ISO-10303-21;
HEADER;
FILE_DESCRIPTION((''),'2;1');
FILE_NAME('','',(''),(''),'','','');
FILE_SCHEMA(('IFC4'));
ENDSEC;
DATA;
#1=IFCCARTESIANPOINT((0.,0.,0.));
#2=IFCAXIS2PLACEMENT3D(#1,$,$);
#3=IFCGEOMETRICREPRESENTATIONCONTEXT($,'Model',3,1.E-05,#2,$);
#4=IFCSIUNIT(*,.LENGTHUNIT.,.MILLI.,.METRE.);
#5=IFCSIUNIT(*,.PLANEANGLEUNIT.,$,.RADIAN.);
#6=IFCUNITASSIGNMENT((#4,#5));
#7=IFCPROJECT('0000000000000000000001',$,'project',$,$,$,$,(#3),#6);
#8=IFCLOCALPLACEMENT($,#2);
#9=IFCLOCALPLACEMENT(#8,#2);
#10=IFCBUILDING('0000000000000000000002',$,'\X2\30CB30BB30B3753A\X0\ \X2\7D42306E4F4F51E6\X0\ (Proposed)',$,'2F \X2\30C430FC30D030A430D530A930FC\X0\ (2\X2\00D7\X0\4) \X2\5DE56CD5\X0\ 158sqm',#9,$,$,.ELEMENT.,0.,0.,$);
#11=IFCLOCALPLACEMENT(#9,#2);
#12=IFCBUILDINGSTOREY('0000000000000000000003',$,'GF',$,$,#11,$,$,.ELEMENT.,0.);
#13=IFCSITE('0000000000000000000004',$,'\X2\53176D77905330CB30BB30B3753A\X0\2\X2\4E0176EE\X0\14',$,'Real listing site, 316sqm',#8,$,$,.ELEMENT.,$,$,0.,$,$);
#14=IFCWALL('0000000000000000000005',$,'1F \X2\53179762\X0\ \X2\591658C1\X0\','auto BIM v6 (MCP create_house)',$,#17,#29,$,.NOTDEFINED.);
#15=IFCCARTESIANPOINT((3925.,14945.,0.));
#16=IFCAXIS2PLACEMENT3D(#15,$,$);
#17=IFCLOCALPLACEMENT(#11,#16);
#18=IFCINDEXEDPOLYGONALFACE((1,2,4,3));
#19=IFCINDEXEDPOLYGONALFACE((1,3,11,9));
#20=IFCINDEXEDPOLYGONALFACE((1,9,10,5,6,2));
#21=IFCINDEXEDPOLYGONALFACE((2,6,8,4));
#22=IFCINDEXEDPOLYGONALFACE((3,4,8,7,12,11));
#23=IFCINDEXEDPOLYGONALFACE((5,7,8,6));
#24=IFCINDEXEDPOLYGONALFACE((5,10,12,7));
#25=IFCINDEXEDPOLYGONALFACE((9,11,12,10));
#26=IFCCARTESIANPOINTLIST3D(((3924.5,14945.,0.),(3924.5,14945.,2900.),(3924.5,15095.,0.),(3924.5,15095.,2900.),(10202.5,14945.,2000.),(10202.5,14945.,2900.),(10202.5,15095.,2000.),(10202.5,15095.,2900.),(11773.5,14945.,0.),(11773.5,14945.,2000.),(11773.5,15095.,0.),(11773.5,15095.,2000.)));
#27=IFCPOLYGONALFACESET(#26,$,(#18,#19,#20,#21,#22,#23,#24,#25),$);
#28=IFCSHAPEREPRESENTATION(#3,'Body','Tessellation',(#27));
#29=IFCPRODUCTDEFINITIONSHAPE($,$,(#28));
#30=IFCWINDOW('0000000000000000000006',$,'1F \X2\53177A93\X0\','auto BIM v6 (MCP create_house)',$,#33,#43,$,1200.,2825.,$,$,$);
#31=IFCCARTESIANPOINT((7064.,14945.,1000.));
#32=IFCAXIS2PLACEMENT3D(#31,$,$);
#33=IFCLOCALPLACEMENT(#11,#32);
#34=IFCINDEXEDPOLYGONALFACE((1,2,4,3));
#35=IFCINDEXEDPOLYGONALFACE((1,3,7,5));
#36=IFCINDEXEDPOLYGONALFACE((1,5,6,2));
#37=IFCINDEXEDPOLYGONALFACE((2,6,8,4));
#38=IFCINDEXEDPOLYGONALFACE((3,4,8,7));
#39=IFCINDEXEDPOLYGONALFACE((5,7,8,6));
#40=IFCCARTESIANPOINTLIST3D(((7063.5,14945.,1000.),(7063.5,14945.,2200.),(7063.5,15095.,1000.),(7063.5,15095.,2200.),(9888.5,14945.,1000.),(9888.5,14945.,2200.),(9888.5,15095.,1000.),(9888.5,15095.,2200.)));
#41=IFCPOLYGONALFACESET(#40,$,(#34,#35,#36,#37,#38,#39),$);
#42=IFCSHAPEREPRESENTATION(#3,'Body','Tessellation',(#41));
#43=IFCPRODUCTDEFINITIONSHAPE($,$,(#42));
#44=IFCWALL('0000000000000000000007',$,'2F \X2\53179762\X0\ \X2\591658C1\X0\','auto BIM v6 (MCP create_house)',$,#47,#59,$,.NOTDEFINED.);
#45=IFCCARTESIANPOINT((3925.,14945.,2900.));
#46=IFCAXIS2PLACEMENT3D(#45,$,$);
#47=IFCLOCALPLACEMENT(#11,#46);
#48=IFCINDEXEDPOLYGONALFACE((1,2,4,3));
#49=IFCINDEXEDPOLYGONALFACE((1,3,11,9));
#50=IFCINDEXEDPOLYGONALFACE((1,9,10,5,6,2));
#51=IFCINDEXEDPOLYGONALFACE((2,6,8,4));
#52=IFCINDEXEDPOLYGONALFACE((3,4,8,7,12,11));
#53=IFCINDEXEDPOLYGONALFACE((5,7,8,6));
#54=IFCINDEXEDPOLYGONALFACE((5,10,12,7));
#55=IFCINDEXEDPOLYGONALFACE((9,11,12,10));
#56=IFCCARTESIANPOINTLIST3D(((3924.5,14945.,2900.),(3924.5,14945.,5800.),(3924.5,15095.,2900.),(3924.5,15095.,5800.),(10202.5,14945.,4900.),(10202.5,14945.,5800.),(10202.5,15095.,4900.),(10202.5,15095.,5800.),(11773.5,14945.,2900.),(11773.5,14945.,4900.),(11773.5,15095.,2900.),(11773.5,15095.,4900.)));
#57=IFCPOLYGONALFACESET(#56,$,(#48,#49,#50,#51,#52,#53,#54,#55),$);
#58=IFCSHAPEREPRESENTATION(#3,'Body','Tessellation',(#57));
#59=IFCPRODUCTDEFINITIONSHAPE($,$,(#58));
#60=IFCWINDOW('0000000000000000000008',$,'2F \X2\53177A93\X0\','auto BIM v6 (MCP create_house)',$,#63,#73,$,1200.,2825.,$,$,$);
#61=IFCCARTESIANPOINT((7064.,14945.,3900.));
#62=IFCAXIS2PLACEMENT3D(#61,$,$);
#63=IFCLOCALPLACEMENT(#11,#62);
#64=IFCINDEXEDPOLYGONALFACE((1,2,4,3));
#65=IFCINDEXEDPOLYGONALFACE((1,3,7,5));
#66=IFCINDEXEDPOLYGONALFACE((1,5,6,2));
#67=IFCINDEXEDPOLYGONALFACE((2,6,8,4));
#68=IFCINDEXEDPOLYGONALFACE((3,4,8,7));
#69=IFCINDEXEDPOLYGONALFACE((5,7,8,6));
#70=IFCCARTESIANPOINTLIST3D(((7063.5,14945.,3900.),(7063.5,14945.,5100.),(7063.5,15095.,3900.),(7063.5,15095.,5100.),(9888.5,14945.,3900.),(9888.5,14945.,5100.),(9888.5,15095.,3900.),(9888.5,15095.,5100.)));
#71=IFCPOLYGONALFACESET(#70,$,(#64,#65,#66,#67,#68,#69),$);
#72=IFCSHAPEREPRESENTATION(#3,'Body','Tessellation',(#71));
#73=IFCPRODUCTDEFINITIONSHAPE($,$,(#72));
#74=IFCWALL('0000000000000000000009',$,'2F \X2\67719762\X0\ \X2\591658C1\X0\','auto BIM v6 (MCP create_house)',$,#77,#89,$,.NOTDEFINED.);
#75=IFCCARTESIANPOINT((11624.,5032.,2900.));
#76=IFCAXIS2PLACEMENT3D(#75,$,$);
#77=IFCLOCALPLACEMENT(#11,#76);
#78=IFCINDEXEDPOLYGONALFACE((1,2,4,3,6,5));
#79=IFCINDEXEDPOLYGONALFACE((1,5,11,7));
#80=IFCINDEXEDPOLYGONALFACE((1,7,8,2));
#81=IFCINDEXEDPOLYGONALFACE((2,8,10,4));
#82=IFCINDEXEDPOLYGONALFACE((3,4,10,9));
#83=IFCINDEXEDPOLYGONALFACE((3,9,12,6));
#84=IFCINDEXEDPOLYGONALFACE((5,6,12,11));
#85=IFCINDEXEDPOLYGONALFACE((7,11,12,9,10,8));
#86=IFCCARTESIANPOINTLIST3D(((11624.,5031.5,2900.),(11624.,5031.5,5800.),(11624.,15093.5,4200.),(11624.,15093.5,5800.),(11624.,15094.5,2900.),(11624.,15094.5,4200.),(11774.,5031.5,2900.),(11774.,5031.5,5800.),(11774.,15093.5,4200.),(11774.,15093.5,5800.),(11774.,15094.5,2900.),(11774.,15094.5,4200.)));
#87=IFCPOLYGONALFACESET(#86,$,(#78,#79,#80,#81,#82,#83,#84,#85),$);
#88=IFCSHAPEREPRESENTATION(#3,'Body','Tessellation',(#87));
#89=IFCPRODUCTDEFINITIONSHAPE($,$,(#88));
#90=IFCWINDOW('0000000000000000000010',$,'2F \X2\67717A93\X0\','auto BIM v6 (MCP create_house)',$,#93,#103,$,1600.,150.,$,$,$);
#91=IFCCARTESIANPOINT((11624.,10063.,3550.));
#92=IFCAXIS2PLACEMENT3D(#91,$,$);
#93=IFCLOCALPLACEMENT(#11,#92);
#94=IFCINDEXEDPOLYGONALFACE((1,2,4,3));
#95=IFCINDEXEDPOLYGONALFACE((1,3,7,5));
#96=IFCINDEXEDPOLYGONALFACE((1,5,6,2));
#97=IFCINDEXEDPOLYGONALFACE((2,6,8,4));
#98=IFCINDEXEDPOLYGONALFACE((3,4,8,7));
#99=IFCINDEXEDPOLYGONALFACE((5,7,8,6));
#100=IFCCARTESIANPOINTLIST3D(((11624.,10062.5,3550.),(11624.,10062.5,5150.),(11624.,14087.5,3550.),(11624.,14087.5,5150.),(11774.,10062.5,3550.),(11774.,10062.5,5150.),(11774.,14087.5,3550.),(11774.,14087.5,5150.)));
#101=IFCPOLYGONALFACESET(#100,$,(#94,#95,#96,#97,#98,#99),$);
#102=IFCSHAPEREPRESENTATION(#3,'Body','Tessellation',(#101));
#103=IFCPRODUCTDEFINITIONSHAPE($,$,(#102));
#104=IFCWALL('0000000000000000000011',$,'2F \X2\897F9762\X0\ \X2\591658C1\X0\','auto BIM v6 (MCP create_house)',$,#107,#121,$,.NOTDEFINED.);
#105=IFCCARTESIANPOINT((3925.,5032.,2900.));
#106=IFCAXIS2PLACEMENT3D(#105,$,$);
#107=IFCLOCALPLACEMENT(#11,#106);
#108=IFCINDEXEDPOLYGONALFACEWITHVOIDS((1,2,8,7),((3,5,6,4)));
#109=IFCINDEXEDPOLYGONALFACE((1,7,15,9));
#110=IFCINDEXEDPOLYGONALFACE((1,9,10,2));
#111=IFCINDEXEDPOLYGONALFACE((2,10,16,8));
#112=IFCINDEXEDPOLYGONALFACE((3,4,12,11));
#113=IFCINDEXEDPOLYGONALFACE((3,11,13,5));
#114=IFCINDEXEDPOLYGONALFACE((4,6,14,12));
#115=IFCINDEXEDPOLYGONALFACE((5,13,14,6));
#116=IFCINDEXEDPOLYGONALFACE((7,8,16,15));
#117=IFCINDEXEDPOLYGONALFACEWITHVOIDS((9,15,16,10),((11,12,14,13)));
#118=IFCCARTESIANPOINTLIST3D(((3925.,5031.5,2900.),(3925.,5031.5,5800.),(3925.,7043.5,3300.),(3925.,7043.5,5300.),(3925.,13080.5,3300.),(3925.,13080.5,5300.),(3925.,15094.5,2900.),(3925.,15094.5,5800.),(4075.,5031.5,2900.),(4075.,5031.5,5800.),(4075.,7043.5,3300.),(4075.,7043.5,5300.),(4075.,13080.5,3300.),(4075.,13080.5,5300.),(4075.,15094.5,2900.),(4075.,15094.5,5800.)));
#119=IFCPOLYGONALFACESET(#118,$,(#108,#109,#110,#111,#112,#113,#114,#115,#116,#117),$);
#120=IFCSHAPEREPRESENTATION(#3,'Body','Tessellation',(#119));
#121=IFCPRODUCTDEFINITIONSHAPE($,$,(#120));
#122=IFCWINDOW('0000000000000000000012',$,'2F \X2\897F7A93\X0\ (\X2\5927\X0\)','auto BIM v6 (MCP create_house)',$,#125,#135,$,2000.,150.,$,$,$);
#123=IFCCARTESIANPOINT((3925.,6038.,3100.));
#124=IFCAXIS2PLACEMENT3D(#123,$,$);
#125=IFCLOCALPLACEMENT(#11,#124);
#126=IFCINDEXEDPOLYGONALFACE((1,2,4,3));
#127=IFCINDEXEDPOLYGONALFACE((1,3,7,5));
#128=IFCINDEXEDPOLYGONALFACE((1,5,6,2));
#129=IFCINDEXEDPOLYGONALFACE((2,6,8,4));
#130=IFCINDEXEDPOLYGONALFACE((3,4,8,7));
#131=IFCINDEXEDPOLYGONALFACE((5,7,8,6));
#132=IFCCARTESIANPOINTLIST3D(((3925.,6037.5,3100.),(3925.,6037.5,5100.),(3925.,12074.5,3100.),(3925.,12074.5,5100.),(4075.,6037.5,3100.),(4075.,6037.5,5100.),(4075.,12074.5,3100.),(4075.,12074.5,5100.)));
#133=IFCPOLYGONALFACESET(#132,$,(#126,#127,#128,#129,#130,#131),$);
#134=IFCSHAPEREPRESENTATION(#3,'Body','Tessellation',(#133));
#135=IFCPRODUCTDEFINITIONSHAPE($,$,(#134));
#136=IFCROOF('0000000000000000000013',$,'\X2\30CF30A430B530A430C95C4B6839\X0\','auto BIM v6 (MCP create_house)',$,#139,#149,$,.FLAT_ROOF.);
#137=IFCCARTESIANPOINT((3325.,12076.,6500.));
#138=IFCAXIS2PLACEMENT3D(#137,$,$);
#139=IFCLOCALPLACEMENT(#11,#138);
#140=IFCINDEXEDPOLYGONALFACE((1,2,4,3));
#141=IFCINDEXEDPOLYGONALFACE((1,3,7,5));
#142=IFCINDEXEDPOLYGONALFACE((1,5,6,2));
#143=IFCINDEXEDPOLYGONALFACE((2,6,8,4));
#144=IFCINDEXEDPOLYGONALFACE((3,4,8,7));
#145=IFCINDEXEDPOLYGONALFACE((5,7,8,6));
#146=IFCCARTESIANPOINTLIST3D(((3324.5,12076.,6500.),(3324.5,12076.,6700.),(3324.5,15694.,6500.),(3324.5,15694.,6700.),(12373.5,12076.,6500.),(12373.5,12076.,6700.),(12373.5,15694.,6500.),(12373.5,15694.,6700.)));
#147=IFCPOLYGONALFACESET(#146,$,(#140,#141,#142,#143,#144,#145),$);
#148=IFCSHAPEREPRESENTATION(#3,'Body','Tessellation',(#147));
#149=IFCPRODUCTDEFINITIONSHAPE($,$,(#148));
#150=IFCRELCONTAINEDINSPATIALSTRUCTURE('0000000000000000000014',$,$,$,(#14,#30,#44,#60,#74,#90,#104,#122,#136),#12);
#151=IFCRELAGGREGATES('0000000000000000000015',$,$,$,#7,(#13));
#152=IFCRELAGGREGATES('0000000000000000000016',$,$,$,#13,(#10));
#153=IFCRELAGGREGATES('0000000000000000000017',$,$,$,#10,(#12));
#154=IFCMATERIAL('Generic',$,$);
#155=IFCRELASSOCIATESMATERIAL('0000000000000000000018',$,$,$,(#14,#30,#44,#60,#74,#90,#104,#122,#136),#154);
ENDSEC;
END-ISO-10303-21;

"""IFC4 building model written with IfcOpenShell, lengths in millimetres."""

from ifc_helpers import new_model, si_unit, frame, frame_2d, origin, place, context, project, spatial, rectangle, extrude, material, element, fill, save


model = new_model("IFC4")

# Units and contexts
model_context = context("Model", 3, precision=1e-05, world=origin())
ifc_project = project(units=[si_unit("LENGTHUNIT", "METRE", prefix="MILLI"), si_unit("PLANEANGLEUNIT", "RADIAN")], contexts=[model_context])

# Site, building, storey
site_placement = place(None, origin())
site = spatial("IfcSite", under=ifc_project, at=site_placement, Name="北海道ニセコ町2丁目14", ObjectType="Real listing site, 316sqm", CompositionType="ELEMENT", RefElevation=0.0)
building_placement = place(site_placement, origin())
building = spatial("IfcBuilding", under=site, at=building_placement, Name="ニセコ町 終の住処 (Proposed)", ObjectType="2F ツーバイフォー (2×4) 工法 158sqm", CompositionType="ELEMENT", ElevationOfRefHeight=0.0, ElevationOfTerrain=0.0)
storey_placement = place(building_placement, origin())
storey = spatial("IfcBuildingStorey", under=building, at=storey_placement, Name="GF", CompositionType="ELEMENT", Elevation=0.0)

# Wall, opening, window
ifc_material = material(Name="Generic")
wall_1_placement = place(storey_placement, frame((3925.0, 14945.0, 0.0)))
wall_1 = element("IfcWall", 1, at=wall_1_placement, inside=storey, material=ifc_material, Name="1F 北面 外壁", Description="auto BIM v6 (MCP create_house)", PredefinedType="NOTDEFINED", context=model_context, shape_type="SweptSolid", body=[
    extrude(rectangle(XDim=7849.0, YDim=150.0, at=frame_2d((3924.0, 75.0))), frame((3925.0, 14945.0, 0.0)), (0.0, 0.0, 1.0), 2900.0),
])
opening_1_placement = place(storey_placement, frame((7064.0, 14945.0, 1000.0)))
opening_1 = element("IfcOpeningElement", 2, at=opening_1_placement, cuts=wall_1, PredefinedType="NOTDEFINED", context=model_context, shape_type="SweptSolid", body=[
    extrude(rectangle(XDim=2825.0, YDim=150.0, at=frame_2d((1412.0, 75.0))), frame((7064.0, 14945.0, 1000.0)), (0.0, 0.0, 1.0), 1200.0),
])
window_1_placement = place(storey_placement, frame((7064.0, 14945.0, 1000.0)))
window_1 = element("IfcWindow", 3, at=window_1_placement, inside=storey, material=ifc_material, Name="1F 北窓", Description="auto BIM v6 (MCP create_house)", OverallHeight=1200.0, OverallWidth=2825.0, context=model_context, shape_type="SweptSolid", body=[
    extrude(rectangle(XDim=2825.0, YDim=150.0, at=frame_2d((1412.0, 75.0))), frame((7064.0, 14945.0, 1000.0)), (0.0, 0.0, 1.0), 1200.0),
])
fill(opening_1, window_1)

# Walls, openings, windows
wall_2_placement = place(storey_placement, frame((3925.0, 14945.0, 2900.0)))
wall_2 = element("IfcWall", 4, at=wall_2_placement, inside=storey, material=ifc_material, Name="2F 北面 外壁", Description="auto BIM v6 (MCP create_house)", PredefinedType="NOTDEFINED", context=model_context, shape_type="SweptSolid", body=[
    extrude(rectangle(XDim=7849.0, YDim=150.0, at=frame_2d((3924.0, 75.0))), frame((3925.0, 14945.0, 2900.0)), (0.0, 0.0, 1.0), 2900.0),
])
opening_2_placement = place(storey_placement, frame((7064.0, 14945.0, 3900.0)))
opening_2 = element("IfcOpeningElement", 5, at=opening_2_placement, cuts=wall_2, PredefinedType="NOTDEFINED", context=model_context, shape_type="SweptSolid", body=[
    extrude(rectangle(XDim=2825.0, YDim=150.0, at=frame_2d((1412.0, 75.0))), frame((7064.0, 14945.0, 3900.0)), (0.0, 0.0, 1.0), 1200.0),
])
window_2_placement = place(storey_placement, frame((7064.0, 14945.0, 3900.0)))
window_2 = element("IfcWindow", 6, at=window_2_placement, inside=storey, material=ifc_material, Name="2F 北窓", Description="auto BIM v6 (MCP create_house)", OverallHeight=1200.0, OverallWidth=2825.0, context=model_context, shape_type="SweptSolid", body=[
    extrude(rectangle(XDim=2825.0, YDim=150.0, at=frame_2d((1412.0, 75.0))), frame((7064.0, 14945.0, 3900.0)), (0.0, 0.0, 1.0), 1200.0),
])
fill(opening_2, window_2)
wall_3_placement = place(storey_placement, frame((11624.0, 5032.0, 2900.0)))
wall_3 = element("IfcWall", 7, at=wall_3_placement, inside=storey, material=ifc_material, Name="2F 東面 外壁", Description="auto BIM v6 (MCP create_house)", PredefinedType="NOTDEFINED", context=model_context, shape_type="SweptSolid", body=[
    extrude(rectangle(XDim=150.0, YDim=10063.0, at=frame_2d((75.0, 5031.0))), frame((11624.0, 5032.0, 2900.0)), (0.0, 0.0, 1.0), 2900.0),
])
opening_3_placement = place(storey_placement, frame((11624.0, 10063.0, 3550.0)))
opening_3 = element("IfcOpeningElement", 8, at=opening_3_placement, cuts=wall_3, PredefinedType="NOTDEFINED", context=model_context, shape_type="SweptSolid", body=[
    extrude(rectangle(XDim=150.0, YDim=4025.0, at=frame_2d((75.0, 2012.0))), frame((11624.0, 10063.0, 3550.0)), (0.0, 0.0, 1.0), 1600.0),
])
window_3_placement = place(storey_placement, frame((11624.0, 10063.0, 3550.0)))
window_3 = element("IfcWindow", 9, at=window_3_placement, inside=storey, material=ifc_material, Name="2F 東窓", Description="auto BIM v6 (MCP create_house)", OverallHeight=1600.0, OverallWidth=150.0, context=model_context, shape_type="SweptSolid", body=[
    extrude(rectangle(XDim=150.0, YDim=4025.0, at=frame_2d((75.0, 2012.0))), frame((11624.0, 10063.0, 3550.0)), (0.0, 0.0, 1.0), 1600.0),
])
fill(opening_3, window_3)
wall_4_placement = place(storey_placement, frame((3925.0, 5032.0, 2900.0)))
wall_4 = element("IfcWall", 10, at=wall_4_placement, inside=storey, material=ifc_material, Name="2F 西面 外壁", Description="auto BIM v6 (MCP create_house)", PredefinedType="NOTDEFINED", context=model_context, shape_type="SweptSolid", body=[
    extrude(rectangle(XDim=150.0, YDim=10063.0, at=frame_2d((75.0, 5031.0))), frame((3925.0, 5032.0, 2900.0)), (0.0, 0.0, 1.0), 2900.0),
])
opening_4_placement = place(storey_placement, frame((3925.0, 6038.0, 3100.0)))
opening_4 = element("IfcOpeningElement", 11, at=opening_4_placement, cuts=wall_4, PredefinedType="NOTDEFINED", context=model_context, shape_type="SweptSolid", body=[
    extrude(rectangle(XDim=150.0, YDim=6037.0, at=frame_2d((75.0, 3018.0))), frame((3925.0, 6038.0, 3100.0)), (0.0, 0.0, 1.0), 2000.0),
])
window_4_placement = place(storey_placement, frame((3925.0, 6038.0, 3100.0)))
window_4 = element("IfcWindow", 12, at=window_4_placement, inside=storey, material=ifc_material, Name="2F 西窓 (大)", Description="auto BIM v6 (MCP create_house)", OverallHeight=2000.0, OverallWidth=150.0, context=model_context, shape_type="SweptSolid", body=[
    extrude(rectangle(XDim=150.0, YDim=6037.0, at=frame_2d((75.0, 3018.0))), frame((3925.0, 6038.0, 3100.0)), (0.0, 0.0, 1.0), 2000.0),
])
fill(opening_4, window_4)

# Roof
roof_placement = place(storey_placement, frame((3325.0, 12076.0, 6500.0)))
element("IfcRoof", 13, at=roof_placement, inside=storey, material=ifc_material, Name="ハイサイド屋根", Description="auto BIM v6 (MCP create_house)", PredefinedType="FLAT_ROOF", context=model_context, shape_type="SweptSolid", body=[
    extrude(rectangle(XDim=9049.0, YDim=3618.0, at=frame_2d((4524.0, 1809.0))), frame((3325.0, 12076.0, 6500.0)), (0.0, 0.0, 1.0), 200.0),
])

save(model, "model.ifc")
